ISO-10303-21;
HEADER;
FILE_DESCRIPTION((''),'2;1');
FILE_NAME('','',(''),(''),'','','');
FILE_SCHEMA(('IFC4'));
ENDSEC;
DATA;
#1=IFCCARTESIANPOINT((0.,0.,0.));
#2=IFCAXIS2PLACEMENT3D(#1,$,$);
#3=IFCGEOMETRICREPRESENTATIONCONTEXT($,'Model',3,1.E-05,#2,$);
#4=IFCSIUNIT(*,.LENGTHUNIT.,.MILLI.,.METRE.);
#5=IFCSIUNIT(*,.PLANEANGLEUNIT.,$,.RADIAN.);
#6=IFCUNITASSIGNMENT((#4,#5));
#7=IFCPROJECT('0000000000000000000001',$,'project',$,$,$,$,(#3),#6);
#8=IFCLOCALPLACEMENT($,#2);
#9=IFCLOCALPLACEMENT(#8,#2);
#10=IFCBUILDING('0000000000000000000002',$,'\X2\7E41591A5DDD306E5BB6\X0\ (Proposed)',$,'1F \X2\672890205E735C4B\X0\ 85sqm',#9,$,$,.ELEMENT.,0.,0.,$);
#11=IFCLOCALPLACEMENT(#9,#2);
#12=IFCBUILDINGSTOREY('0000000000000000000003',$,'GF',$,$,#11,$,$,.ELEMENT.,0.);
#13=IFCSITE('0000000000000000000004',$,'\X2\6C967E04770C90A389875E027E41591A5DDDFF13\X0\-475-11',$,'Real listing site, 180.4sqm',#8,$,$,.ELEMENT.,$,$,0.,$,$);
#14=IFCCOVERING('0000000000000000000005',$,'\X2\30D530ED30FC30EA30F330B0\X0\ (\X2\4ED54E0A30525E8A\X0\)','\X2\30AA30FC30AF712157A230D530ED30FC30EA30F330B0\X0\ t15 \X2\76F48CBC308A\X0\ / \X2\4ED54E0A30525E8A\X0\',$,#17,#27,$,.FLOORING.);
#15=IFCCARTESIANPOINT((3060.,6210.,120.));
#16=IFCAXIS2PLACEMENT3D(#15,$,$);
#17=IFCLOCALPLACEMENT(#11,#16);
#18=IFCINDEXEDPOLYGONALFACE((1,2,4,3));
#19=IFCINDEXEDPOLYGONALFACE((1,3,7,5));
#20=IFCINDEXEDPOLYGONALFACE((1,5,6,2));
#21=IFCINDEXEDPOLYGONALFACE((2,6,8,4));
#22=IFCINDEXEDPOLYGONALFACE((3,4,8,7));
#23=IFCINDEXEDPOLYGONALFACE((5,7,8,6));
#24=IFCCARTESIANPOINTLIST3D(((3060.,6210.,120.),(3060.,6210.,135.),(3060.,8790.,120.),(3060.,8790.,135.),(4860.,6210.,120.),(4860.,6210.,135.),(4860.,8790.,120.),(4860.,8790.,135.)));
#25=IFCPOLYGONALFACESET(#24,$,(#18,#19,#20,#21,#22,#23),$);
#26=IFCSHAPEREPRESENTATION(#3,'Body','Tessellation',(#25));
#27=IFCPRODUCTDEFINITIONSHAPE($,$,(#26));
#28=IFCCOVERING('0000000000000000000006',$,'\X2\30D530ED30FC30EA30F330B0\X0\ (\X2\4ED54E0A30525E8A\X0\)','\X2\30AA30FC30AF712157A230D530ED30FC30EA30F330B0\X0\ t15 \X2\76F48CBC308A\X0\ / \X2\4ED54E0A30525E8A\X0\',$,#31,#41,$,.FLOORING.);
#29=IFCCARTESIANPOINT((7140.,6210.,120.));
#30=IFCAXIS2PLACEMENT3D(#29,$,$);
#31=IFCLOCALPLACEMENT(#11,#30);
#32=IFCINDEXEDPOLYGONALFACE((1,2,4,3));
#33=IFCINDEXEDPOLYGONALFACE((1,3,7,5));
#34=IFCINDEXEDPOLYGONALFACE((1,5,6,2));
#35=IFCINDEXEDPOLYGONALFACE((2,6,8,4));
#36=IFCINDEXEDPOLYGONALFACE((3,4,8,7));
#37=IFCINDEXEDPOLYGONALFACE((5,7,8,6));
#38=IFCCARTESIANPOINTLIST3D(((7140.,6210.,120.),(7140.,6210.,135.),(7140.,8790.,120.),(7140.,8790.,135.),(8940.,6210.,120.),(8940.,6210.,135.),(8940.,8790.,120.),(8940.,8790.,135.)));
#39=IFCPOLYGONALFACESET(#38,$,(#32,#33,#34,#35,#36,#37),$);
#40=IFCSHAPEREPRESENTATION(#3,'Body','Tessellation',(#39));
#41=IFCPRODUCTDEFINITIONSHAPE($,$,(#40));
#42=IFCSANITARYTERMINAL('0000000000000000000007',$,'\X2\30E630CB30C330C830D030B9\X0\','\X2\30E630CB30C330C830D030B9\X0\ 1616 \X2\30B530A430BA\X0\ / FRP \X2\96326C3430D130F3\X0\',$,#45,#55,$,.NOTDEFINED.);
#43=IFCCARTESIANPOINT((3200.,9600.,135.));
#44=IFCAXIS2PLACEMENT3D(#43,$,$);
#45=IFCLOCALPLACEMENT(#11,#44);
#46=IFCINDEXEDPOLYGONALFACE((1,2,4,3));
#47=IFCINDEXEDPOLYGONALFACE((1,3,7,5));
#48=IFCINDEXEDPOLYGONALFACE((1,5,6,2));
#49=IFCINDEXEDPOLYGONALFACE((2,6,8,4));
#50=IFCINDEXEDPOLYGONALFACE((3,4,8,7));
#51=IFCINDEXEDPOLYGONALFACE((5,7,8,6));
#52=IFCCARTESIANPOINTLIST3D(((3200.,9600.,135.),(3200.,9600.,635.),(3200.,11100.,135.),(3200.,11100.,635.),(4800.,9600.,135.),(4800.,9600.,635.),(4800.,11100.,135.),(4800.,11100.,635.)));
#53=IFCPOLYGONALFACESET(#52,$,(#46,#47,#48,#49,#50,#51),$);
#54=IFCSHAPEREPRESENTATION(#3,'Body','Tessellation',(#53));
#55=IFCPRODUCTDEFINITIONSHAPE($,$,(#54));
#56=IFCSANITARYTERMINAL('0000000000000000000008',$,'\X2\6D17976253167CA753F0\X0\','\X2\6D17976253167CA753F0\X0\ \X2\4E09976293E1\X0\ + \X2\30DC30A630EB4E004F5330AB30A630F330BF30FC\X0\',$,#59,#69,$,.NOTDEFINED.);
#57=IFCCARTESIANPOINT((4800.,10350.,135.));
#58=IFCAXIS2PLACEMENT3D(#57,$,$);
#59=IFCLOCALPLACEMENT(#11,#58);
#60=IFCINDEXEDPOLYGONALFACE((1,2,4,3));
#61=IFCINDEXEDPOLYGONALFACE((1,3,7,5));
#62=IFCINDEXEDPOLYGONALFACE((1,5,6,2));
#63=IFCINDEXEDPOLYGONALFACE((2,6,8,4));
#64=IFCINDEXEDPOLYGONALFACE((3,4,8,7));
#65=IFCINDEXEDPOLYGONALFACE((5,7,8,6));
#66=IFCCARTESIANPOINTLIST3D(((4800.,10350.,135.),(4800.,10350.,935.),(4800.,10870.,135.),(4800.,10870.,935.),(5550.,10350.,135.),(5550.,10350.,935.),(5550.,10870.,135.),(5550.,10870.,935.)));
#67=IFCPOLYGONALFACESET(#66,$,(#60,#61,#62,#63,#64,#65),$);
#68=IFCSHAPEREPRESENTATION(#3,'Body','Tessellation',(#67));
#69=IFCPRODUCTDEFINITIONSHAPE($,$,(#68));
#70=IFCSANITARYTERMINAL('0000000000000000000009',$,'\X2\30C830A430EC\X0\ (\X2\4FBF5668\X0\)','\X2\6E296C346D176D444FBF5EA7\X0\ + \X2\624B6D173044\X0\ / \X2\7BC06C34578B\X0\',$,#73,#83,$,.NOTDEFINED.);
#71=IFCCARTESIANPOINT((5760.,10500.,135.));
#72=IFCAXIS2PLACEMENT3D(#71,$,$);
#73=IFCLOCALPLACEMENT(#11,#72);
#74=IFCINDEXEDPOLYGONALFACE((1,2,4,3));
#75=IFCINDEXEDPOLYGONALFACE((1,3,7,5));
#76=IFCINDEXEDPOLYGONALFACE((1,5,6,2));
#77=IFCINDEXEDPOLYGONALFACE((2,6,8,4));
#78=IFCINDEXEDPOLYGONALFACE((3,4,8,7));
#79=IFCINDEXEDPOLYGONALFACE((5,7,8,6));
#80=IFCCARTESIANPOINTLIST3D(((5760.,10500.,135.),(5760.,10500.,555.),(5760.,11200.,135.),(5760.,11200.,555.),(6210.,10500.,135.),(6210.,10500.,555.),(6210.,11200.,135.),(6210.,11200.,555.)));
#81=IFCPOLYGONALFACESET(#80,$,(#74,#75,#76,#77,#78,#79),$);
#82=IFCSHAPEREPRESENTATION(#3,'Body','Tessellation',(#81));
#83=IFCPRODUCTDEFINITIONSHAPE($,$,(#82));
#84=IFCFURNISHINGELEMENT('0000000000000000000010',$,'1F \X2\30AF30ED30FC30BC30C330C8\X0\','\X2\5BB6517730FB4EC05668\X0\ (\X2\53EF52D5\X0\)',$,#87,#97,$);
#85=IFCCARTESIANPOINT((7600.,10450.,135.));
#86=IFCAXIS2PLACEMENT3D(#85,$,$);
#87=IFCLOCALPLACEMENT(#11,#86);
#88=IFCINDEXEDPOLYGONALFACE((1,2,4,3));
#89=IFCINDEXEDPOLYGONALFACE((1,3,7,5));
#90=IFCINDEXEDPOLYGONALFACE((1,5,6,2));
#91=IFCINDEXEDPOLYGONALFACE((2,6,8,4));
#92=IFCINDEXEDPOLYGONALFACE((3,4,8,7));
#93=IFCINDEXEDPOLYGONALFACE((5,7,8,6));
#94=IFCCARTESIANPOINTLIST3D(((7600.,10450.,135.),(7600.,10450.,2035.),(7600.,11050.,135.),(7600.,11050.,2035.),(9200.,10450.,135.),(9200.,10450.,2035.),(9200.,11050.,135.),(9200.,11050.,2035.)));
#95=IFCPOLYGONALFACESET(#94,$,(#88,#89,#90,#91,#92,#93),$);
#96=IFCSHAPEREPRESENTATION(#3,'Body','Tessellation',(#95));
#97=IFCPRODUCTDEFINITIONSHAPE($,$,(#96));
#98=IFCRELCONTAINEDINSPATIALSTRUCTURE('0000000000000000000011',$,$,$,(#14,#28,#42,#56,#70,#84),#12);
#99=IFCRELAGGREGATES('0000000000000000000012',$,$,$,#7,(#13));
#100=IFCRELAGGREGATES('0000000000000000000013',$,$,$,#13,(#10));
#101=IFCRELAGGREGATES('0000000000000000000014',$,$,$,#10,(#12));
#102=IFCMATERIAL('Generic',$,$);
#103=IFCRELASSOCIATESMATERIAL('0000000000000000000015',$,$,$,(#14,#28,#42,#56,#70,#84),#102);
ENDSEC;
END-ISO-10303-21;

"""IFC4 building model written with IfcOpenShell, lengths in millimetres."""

from ifc_helpers import new_model, si_unit, frame, frame_2d, origin, place, context, project, spatial, rectangle, extrude, material, element, save


model = new_model("IFC4")

# Units and contexts
model_context = context("Model", 3, precision=1e-05, world=origin())
ifc_project = project(units=[si_unit("LENGTHUNIT", "METRE", prefix="MILLI"), si_unit("PLANEANGLEUNIT", "RADIAN")], contexts=[model_context])

# Site, building, storey
site_placement = place(None, origin())
site = spatial("IfcSite", under=ifc_project, at=site_placement, Name="沖縄県那覇市繁多川３-475-11", ObjectType="Real listing site, 180.4sqm", CompositionType="ELEMENT", RefElevation=0.0)
building_placement = place(site_placement, origin())
building = spatial("IfcBuilding", under=site, at=building_placement, Name="繁多川の家 (Proposed)", ObjectType="1F 木造平屋 85sqm", CompositionType="ELEMENT", ElevationOfRefHeight=0.0, ElevationOfTerrain=0.0)
storey_placement = place(building_placement, origin())
storey = spatial("IfcBuildingStorey", under=building, at=storey_placement, Name="GF", CompositionType="ELEMENT", Elevation=0.0)

# Coverings
ifc_material_1 = material(Name="Generic")
covering_1_placement = place(storey_placement, frame((3060.0, 6210.0, 120.0)))
element("IfcCovering", 1, at=covering_1_placement, inside=storey, material=ifc_material_1, Name="フローリング (仕上げ床)", Description="オーク無垢フローリング t15 直貼り / 仕上げ床", PredefinedType="FLOORING", context=model_context, shape_type="SweptSolid", body=[
    extrude(rectangle(XDim=1800.0, YDim=2580.0, at=frame_2d((900.0, 1290.0))), frame((3060.0, 6210.0, 120.0)), (0.0, 0.0, 1.0), 15.0),
])
covering_2_placement = place(storey_placement, frame((7140.0, 6210.0, 120.0)))
element("IfcCovering", 2, at=covering_2_placement, inside=storey, material=ifc_material_1, Name="フローリング (仕上げ床)", Description="オーク無垢フローリング t15 直貼り / 仕上げ床", PredefinedType="FLOORING", context=model_context, shape_type="SweptSolid", body=[
    extrude(rectangle(XDim=1800.0, YDim=2580.0, at=frame_2d((900.0, 1290.0))), frame((7140.0, 6210.0, 120.0)), (0.0, 0.0, 1.0), 15.0),
])

# Sanitary terminals
sanitary_terminal_1_placement = place(storey_placement, frame((3200.0, 9600.0, 135.0)))
element("IfcSanitaryTerminal", 3, at=sanitary_terminal_1_placement, inside=storey, material=ifc_material_1, Name="ユニットバス", Description="ユニットバス 1616 サイズ / FRP 防水パン", PredefinedType="NOTDEFINED", context=model_context, shape_type="SweptSolid", body=[
    extrude(rectangle(XDim=1600.0, YDim=1500.0, at=frame_2d((800.0, 750.0))), frame((3200.0, 9600.0, 135.0)), (0.0, 0.0, 1.0), 500.0),
])
sanitary_terminal_2_placement = place(storey_placement, frame((4800.0, 10350.0, 135.0)))
element("IfcSanitaryTerminal", 4, at=sanitary_terminal_2_placement, inside=storey, material=ifc_material_1, Name="洗面化粧台", Description="洗面化粧台 三面鏡 + ボウル一体カウンター", PredefinedType="NOTDEFINED", context=model_context, shape_type="SweptSolid", body=[
    extrude(rectangle(XDim=750.0, YDim=520.0, at=frame_2d((375.0, 260.0))), frame((4800.0, 10350.0, 135.0)), (0.0, 0.0, 1.0), 800.0),
])
sanitary_terminal_3_placement = place(storey_placement, frame((5760.0, 10500.0, 135.0)))
element("IfcSanitaryTerminal", 5, at=sanitary_terminal_3_placement, inside=storey, material=ifc_material_1, Name="トイレ (便器)", Description="温水洗浄便座 + 手洗い / 節水型", PredefinedType="NOTDEFINED", context=model_context, shape_type="SweptSolid", body=[
    extrude(rectangle(XDim=450.0, YDim=700.0, at=frame_2d((225.0, 350.0))), frame((5760.0, 10500.0, 135.0)), (0.0, 0.0, 1.0), 420.0),
])

# Furnishing element
furnishing_placement = place(storey_placement, frame((7600.0, 10450.0, 135.0)))
element("IfcFurnishingElement", 6, at=furnishing_placement, inside=storey, material=ifc_material_1, Name="1F クローゼット", Description="家具・什器 (可動)", context=model_context, shape_type="SweptSolid", body=[
    extrude(rectangle(XDim=1600.0, YDim=600.0, at=frame_2d((800.0, 300.0))), frame((7600.0, 10450.0, 135.0)), (0.0, 0.0, 1.0), 1900.0),
])

save(model, "model.ifc")
